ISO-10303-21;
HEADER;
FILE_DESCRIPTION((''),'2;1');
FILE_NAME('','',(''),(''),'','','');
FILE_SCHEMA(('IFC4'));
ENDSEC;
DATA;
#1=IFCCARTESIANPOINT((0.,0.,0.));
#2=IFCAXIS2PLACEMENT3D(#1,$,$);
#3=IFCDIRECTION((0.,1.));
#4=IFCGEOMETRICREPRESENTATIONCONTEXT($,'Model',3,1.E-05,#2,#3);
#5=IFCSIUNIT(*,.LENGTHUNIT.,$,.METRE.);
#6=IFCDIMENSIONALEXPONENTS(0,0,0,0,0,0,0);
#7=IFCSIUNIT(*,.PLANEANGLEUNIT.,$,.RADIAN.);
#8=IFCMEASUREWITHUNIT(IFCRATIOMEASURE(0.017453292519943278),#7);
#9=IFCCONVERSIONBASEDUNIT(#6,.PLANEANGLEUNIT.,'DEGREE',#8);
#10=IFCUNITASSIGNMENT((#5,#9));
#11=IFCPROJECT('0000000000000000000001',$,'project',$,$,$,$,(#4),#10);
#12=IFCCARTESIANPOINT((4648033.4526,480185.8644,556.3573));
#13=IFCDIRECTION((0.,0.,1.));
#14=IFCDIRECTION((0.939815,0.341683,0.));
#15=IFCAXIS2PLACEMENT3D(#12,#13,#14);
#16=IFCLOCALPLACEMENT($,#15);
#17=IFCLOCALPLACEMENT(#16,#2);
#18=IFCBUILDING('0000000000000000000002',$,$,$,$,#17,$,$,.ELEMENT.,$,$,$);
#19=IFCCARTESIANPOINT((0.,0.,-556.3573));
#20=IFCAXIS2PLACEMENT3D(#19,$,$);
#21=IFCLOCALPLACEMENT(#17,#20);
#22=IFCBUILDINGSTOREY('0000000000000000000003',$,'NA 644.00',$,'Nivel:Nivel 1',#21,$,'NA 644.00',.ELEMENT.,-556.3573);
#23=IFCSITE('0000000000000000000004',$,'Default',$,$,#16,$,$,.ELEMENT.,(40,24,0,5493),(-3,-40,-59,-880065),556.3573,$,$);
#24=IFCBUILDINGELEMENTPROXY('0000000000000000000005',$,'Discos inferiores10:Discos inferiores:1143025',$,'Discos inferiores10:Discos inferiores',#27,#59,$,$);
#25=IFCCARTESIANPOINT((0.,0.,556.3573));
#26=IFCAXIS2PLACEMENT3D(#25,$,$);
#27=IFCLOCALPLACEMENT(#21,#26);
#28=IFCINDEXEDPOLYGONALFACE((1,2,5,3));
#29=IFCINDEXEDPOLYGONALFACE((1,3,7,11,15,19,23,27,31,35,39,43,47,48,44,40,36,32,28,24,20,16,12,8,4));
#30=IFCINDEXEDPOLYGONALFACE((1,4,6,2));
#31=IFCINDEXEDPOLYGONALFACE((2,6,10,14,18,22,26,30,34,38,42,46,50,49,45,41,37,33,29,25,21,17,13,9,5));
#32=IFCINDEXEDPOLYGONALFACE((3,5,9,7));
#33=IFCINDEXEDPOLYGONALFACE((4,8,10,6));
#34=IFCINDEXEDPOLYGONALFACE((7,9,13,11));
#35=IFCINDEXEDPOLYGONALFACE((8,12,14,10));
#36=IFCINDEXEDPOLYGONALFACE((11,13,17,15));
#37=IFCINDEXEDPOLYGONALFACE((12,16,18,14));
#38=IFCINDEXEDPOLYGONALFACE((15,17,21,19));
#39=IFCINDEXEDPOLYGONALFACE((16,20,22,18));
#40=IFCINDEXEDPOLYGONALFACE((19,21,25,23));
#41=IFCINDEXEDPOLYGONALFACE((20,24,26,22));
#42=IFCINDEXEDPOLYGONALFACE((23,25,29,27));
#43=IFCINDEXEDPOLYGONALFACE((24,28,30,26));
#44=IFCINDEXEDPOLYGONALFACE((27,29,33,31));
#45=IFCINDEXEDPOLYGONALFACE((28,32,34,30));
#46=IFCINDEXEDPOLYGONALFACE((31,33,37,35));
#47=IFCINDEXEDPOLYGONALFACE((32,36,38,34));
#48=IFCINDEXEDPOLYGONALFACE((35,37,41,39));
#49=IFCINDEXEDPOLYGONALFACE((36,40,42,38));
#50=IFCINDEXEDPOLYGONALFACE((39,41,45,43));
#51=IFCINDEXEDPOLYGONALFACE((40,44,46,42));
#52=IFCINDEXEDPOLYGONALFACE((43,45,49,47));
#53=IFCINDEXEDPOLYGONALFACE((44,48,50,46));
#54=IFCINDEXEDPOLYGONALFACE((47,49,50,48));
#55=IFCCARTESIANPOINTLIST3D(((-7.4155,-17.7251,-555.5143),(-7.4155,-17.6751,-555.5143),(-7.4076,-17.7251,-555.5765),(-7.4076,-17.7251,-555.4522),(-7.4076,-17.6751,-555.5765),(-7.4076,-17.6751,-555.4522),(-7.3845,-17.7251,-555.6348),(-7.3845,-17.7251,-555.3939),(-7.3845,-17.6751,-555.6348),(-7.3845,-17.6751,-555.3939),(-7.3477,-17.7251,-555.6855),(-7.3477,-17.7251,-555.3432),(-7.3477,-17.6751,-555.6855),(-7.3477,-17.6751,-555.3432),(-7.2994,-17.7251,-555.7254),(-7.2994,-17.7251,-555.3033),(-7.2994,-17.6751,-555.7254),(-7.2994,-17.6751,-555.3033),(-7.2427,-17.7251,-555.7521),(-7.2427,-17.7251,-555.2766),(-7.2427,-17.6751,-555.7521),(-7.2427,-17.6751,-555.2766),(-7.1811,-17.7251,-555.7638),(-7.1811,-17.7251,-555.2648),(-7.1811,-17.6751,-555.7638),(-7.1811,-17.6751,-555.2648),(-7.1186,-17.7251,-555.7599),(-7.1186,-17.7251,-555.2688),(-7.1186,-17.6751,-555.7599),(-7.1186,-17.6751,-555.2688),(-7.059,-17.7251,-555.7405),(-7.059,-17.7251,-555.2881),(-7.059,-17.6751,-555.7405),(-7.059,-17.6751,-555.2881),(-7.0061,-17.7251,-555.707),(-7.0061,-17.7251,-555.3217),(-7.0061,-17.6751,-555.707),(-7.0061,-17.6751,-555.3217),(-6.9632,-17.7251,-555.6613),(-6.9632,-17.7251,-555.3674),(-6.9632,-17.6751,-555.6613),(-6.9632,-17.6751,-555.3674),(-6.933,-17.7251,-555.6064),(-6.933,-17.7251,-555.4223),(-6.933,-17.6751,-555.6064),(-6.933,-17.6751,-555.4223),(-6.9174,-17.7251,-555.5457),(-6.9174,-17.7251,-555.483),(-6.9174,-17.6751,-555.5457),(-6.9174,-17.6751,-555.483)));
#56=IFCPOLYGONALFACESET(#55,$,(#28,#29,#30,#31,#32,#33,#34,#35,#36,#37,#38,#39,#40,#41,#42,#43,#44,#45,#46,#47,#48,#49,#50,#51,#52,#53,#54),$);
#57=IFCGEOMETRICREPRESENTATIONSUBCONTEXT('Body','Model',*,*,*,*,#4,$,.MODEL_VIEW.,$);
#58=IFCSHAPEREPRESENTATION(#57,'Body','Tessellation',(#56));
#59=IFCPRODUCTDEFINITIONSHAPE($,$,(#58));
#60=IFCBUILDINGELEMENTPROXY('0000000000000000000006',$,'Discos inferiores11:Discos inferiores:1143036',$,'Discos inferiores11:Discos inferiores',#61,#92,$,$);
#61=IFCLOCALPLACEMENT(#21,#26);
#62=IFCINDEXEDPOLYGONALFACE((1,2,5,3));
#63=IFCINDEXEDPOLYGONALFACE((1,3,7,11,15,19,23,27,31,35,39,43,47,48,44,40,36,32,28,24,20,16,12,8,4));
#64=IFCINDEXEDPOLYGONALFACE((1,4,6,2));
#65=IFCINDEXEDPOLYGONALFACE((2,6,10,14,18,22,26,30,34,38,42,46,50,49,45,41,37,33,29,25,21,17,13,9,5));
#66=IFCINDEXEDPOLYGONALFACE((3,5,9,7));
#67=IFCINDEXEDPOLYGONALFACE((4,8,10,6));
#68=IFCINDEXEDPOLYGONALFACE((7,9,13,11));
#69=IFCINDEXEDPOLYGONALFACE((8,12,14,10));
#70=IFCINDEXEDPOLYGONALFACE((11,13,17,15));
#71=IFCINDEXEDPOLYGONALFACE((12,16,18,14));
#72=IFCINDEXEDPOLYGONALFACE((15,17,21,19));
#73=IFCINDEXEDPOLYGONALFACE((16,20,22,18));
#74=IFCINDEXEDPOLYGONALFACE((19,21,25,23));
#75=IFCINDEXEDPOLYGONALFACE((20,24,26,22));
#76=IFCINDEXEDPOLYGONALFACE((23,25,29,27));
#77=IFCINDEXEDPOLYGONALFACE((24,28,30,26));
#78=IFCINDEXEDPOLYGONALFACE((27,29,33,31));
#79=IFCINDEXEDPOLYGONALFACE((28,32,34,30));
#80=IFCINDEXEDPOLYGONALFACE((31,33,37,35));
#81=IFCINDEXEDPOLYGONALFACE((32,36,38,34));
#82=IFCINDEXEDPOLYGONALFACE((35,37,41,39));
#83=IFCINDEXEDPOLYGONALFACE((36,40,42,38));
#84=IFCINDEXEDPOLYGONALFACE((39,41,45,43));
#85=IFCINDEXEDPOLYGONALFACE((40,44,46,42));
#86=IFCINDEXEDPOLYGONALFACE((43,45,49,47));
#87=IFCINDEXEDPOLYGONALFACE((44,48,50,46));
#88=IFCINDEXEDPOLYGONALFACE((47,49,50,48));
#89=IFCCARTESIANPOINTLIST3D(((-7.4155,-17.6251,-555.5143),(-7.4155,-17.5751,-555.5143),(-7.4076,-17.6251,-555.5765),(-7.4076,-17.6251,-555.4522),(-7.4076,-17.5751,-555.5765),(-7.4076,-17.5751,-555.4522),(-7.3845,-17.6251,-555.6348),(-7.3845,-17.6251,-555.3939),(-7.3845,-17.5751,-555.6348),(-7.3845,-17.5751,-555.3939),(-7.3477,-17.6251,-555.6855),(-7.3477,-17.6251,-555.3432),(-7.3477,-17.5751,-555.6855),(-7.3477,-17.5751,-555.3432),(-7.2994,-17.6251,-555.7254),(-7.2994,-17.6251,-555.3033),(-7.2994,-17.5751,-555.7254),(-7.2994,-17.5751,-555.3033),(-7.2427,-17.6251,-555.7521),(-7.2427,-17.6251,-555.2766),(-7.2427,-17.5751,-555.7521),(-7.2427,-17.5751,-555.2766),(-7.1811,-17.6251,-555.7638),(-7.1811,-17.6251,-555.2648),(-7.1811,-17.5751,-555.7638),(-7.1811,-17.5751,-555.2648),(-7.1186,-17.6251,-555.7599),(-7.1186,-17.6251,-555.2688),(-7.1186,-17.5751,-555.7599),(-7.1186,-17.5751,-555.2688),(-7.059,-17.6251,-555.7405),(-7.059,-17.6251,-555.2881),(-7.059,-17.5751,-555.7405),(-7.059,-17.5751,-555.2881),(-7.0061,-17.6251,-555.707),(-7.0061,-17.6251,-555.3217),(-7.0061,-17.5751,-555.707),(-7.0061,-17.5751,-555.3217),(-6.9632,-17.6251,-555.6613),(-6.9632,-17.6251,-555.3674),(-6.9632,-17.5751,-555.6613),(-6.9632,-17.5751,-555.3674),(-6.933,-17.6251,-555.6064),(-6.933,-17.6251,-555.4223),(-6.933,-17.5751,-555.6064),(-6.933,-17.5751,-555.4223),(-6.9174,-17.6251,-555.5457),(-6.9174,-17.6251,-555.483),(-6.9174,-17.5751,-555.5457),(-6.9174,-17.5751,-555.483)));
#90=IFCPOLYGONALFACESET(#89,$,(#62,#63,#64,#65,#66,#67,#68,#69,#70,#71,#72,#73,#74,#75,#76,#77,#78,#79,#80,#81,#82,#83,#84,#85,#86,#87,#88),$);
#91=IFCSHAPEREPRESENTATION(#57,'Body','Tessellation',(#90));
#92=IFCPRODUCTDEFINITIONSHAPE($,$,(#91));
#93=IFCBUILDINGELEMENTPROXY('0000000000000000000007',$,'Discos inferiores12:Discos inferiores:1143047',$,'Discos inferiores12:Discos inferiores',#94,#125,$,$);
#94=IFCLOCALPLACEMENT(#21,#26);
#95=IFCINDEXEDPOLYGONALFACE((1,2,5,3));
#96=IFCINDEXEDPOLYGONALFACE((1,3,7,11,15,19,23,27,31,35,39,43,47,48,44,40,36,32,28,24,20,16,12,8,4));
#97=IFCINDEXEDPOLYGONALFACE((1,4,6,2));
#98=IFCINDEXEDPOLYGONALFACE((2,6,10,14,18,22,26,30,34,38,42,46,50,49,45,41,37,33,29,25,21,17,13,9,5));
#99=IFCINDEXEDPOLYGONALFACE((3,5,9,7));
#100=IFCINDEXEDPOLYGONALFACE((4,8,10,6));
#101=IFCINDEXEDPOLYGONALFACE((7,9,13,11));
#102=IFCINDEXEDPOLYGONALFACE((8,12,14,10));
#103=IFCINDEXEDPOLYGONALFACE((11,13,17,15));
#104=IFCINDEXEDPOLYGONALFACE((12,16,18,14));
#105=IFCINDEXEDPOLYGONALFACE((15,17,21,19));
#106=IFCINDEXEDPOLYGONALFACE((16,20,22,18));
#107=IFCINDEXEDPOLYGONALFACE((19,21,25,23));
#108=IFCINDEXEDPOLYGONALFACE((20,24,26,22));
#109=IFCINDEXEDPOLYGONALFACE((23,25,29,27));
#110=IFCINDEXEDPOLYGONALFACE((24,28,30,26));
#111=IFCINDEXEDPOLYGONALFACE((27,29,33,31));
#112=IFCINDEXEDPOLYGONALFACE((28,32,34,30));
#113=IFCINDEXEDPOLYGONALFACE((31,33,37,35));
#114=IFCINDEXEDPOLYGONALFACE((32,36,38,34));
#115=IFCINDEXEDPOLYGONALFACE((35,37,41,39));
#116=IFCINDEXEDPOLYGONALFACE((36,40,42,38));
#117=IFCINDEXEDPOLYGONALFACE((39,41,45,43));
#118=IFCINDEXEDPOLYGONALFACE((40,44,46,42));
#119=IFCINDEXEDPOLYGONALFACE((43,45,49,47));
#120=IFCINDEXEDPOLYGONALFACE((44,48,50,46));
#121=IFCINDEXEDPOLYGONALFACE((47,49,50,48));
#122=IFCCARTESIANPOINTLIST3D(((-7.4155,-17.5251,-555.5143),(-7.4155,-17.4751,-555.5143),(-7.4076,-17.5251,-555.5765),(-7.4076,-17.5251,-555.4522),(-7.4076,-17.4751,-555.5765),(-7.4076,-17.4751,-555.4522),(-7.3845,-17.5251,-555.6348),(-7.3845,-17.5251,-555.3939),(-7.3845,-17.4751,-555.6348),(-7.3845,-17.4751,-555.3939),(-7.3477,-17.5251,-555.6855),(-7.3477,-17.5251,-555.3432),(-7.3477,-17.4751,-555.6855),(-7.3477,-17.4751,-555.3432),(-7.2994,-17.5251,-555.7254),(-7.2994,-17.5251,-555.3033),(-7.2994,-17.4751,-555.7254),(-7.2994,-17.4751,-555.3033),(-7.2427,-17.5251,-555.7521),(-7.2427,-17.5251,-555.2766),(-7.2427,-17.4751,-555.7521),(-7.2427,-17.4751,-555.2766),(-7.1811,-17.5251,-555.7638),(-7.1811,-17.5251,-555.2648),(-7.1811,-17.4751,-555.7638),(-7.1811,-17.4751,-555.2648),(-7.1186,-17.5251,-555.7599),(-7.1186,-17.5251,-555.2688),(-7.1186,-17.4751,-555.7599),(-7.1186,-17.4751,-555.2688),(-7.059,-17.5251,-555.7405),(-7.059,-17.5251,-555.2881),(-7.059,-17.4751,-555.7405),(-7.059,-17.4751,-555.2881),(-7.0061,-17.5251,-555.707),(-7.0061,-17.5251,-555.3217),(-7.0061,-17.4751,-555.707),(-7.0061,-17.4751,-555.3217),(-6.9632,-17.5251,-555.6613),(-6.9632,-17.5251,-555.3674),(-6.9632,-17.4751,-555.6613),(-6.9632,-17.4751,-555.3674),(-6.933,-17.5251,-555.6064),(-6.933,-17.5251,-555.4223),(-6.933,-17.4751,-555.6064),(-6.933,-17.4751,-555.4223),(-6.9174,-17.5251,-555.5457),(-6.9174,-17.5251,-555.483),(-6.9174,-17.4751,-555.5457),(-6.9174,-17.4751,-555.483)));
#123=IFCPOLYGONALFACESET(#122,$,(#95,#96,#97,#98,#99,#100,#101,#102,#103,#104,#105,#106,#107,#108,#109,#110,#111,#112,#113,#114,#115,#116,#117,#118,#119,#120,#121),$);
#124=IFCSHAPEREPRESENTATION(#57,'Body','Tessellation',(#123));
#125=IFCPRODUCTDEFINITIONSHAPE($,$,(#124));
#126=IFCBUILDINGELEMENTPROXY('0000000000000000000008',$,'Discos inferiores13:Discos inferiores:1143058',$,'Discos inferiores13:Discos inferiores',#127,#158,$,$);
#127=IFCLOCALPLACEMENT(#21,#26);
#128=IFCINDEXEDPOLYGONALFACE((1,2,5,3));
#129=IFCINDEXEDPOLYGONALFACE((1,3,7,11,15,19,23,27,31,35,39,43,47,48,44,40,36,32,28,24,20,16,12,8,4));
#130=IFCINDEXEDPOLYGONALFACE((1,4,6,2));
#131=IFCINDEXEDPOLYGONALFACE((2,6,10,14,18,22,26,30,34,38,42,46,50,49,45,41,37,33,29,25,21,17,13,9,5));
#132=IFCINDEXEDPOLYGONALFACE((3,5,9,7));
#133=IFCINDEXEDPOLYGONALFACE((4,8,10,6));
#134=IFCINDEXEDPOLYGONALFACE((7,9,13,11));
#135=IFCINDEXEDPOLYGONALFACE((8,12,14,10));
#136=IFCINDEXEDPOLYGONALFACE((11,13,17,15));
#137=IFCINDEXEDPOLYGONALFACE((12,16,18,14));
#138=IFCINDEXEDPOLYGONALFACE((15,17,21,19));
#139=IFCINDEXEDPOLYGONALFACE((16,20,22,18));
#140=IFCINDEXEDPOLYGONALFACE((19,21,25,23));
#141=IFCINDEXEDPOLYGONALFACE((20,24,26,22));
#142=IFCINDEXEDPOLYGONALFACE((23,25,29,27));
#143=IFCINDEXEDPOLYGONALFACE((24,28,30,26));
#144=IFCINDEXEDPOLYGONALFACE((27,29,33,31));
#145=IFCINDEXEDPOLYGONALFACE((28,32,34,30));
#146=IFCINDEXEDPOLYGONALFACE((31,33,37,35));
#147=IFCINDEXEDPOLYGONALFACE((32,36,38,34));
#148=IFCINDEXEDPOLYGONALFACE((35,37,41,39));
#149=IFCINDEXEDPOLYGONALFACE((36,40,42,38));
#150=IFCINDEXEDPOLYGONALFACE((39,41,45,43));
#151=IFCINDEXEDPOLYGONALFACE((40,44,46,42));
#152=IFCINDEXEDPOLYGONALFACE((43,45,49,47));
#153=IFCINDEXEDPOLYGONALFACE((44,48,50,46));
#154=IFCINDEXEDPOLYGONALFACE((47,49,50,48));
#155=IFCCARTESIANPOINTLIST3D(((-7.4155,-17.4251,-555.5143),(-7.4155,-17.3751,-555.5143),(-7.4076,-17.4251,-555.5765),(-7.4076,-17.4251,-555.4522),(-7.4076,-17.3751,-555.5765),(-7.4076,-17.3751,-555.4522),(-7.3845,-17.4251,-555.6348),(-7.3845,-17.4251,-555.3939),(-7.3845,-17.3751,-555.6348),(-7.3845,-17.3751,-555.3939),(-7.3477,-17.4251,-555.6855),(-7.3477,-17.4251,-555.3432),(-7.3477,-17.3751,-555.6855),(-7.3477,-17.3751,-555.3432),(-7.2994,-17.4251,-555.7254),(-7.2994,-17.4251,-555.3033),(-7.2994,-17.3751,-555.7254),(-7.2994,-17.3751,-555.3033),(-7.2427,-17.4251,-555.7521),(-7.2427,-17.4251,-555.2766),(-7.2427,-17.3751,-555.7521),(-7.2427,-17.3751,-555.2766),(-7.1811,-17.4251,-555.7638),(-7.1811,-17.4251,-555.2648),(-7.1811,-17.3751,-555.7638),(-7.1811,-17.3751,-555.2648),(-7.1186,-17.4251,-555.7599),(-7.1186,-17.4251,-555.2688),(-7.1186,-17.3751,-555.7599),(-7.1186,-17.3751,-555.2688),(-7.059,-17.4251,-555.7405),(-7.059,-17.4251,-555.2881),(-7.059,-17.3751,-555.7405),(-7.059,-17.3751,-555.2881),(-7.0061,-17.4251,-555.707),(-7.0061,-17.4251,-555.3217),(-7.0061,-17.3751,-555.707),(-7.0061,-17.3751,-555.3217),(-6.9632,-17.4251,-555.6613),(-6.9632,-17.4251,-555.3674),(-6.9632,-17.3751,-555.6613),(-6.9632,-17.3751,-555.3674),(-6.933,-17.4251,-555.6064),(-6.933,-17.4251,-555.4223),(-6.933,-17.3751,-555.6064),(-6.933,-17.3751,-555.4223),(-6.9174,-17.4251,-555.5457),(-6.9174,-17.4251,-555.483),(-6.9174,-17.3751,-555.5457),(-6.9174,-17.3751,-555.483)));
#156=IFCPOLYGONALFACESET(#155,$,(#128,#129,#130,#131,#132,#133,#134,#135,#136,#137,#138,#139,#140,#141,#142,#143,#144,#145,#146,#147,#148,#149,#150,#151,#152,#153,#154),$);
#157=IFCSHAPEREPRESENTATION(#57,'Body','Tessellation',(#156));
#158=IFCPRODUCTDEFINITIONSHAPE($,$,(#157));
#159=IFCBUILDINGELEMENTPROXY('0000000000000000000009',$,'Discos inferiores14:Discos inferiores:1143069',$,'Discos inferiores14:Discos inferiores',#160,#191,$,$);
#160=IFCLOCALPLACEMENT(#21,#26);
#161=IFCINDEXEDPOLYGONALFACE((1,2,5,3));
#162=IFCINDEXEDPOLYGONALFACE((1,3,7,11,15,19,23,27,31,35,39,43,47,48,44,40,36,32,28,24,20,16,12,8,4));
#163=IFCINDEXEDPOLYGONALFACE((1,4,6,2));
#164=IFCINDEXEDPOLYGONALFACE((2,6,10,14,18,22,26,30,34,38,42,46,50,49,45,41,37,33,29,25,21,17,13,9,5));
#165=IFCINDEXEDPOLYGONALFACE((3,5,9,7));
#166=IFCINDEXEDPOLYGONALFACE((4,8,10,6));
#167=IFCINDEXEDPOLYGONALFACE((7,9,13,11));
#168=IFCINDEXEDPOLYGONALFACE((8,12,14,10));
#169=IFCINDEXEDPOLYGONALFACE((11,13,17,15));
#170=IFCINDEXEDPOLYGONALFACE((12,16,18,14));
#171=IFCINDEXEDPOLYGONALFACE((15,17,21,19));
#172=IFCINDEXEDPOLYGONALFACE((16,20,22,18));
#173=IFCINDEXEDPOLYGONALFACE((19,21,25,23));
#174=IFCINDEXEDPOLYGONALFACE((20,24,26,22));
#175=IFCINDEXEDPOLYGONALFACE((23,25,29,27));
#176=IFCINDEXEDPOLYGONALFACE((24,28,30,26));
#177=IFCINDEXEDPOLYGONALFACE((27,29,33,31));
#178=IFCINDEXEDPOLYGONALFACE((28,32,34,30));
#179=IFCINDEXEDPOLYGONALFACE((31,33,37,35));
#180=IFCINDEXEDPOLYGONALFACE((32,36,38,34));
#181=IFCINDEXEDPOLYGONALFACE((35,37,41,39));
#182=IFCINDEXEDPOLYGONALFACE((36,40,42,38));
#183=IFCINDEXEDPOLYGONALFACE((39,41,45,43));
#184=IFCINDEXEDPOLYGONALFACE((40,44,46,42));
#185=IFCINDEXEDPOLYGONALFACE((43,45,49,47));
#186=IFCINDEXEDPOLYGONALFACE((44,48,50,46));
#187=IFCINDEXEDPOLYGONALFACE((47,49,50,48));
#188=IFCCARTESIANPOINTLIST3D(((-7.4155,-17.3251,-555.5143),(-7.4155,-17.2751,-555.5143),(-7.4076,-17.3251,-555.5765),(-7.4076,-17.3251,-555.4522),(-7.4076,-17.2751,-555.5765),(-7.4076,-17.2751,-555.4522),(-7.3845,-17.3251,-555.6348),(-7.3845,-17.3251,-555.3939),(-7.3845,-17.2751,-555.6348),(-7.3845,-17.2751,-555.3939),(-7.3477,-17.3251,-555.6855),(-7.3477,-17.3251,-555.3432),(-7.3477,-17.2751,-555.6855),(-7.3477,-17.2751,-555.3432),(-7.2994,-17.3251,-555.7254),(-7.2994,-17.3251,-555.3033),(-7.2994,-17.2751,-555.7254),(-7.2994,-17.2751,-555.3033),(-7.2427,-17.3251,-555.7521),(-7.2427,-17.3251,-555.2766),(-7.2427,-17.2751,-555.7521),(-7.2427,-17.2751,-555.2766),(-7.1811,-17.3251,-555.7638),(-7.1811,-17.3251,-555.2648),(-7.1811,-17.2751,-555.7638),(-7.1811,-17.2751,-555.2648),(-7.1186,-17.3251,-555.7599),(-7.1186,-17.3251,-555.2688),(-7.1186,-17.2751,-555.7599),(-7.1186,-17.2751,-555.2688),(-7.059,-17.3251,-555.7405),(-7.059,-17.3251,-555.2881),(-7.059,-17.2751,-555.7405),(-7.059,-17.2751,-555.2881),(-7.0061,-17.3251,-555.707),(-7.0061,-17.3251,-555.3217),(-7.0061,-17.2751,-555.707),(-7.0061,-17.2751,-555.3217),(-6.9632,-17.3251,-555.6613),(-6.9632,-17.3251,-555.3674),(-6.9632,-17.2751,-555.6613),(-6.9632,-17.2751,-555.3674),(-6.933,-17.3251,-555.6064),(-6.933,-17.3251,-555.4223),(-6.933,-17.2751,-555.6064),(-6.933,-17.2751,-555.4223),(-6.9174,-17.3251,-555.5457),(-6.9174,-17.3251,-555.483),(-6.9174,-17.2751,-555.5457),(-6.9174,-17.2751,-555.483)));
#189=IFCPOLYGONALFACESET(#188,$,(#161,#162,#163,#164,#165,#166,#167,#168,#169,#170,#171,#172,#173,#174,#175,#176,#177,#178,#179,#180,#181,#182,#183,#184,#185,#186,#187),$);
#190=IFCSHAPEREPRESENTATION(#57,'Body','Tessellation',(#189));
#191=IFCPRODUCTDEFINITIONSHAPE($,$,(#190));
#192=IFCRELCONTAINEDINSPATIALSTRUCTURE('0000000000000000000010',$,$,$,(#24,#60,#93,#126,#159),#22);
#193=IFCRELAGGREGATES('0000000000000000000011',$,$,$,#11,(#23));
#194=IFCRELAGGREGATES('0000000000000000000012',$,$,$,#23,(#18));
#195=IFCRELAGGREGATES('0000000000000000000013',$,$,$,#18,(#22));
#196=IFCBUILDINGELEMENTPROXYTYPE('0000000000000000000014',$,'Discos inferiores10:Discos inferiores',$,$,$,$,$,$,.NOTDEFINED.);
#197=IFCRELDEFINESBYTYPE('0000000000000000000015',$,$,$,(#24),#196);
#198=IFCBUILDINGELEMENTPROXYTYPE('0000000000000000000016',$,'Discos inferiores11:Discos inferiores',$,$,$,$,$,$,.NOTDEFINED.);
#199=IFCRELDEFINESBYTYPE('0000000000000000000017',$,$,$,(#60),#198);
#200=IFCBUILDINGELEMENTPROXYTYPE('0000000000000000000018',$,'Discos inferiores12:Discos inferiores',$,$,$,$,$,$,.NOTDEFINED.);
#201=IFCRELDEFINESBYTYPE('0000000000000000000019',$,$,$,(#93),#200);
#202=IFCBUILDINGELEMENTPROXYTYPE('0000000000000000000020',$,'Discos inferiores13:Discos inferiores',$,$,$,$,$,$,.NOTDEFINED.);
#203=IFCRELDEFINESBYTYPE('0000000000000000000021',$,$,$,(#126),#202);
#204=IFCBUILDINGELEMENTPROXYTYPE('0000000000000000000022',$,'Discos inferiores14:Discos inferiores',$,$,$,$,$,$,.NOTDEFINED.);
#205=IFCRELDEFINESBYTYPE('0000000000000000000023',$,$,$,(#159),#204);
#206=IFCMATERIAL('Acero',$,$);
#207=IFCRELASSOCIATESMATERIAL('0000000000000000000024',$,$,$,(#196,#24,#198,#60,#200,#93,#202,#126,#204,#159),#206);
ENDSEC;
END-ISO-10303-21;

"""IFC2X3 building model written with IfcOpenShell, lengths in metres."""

from ifc_helpers import new_model, entity, si_unit, converted_unit, direction, frame, origin, origin_2d_with_axis, place, context, subcontext, project, spatial, circle, extrude, source, transform, mapped, material, type_object, type_shapes, element, save


model = new_model("IFC2X3")

# Units and contexts
model_context = context("Model", 3, precision=1e-05, world=origin(), true_north=direction((0.0, 1.0)))
body_context = subcontext(model_context, "Body", "Model", "MODEL_VIEW")
ifc_project = project(units=[si_unit("LENGTHUNIT", "METRE"), converted_unit("PLANEANGLEUNIT", "DEGREE", entity("IfcRatioMeasure", 0.017453292519943278), si_unit("PLANEANGLEUNIT", "RADIAN"), dimensions=[0, 0, 0, 0, 0, 0, 0])], contexts=[model_context])

# Site, building, storey
site_placement = place(None, frame((4648033.4526, 480185.8644, 556.3573), z_axis=(0.0, 0.0, 1.0), x_axis=(0.939815, 0.341683, 0.0)))
site = spatial("IfcSite", under=ifc_project, at=site_placement, Name="Default", CompositionType="ELEMENT", RefLatitude=(40, 24, 0, 5493), RefLongitude=(-3, -40, -59, -880065), RefElevation=556.3573)
building_placement = place(site_placement, origin())
building = spatial("IfcBuilding", under=site, at=building_placement, CompositionType="ELEMENT")
storey_placement = place(building_placement, frame((0.0, 0.0, -556.3573)))
storey = spatial("IfcBuildingStorey", under=building, at=storey_placement, Name="NA 644.00", ObjectType="Nivel:Nivel 1", LongName="NA 644.00", CompositionType="ELEMENT", Elevation=-556.3573)

# Building element proxies
ifc_material_1 = material(Name="Acero")
building_element_proxy_type_1 = type_object("IfcBuildingElementProxyType", Name="Discos inferiores10:Discos inferiores", PredefinedType="NOTDEFINED", material=ifc_material_1)
shared_shape_1 = source(origin(), body_context, "Body", "SweptSolid", [
    extrude(circle(Radius=0.25, at=origin_2d_with_axis()), frame((-7.1655, -17.7251, -555.5143), z_axis=(0.0, 1.0, 0.0), x_axis=(-1.0, 0.0, 0.0)), (0.0, 0.0, 1.0), 0.05),
])
type_shapes(building_element_proxy_type_1, [shared_shape_1])
proxy_1_placement = place(storey_placement, frame((0.0, 0.0, 556.3573)))
element("IfcBuildingElementProxy", 1, at=proxy_1_placement, inside=storey, type_object=building_element_proxy_type_1, material=ifc_material_1, Name="Discos inferiores10:Discos inferiores:1143025", ObjectType="Discos inferiores10:Discos inferiores", context=body_context, shape_type="MappedRepresentation", body=[
    mapped(shared_shape_1, transform((0.0, 0.0, 0.0), scale=1.0)),
])
building_element_proxy_type_2 = type_object("IfcBuildingElementProxyType", Name="Discos inferiores11:Discos inferiores", PredefinedType="NOTDEFINED", material=ifc_material_1)
shared_shape_2 = source(origin(), body_context, "Body", "SweptSolid", [
    extrude(circle(Radius=0.25, at=origin_2d_with_axis()), frame((-7.1655, -17.6251, -555.5143), z_axis=(0.0, 1.0, 0.0), x_axis=(-1.0, 0.0, 0.0)), (0.0, 0.0, 1.0), 0.05),
])
type_shapes(building_element_proxy_type_2, [shared_shape_2])
proxy_2_placement = place(storey_placement, frame((0.0, 0.0, 556.3573)))
element("IfcBuildingElementProxy", 2, at=proxy_2_placement, inside=storey, type_object=building_element_proxy_type_2, material=ifc_material_1, Name="Discos inferiores11:Discos inferiores:1143036", ObjectType="Discos inferiores11:Discos inferiores", context=body_context, shape_type="MappedRepresentation", body=[
    mapped(shared_shape_2, transform((0.0, 0.0, 0.0), scale=1.0)),
])
building_element_proxy_type_3 = type_object("IfcBuildingElementProxyType", Name="Discos inferiores12:Discos inferiores", PredefinedType="NOTDEFINED", material=ifc_material_1)
shared_shape_3 = source(origin(), body_context, "Body", "SweptSolid", [
    extrude(circle(Radius=0.25, at=origin_2d_with_axis()), frame((-7.1655, -17.5251, -555.5143), z_axis=(0.0, 1.0, 0.0), x_axis=(-1.0, 0.0, 0.0)), (0.0, 0.0, 1.0), 0.05),
])
type_shapes(building_element_proxy_type_3, [shared_shape_3])
proxy_3_placement = place(storey_placement, frame((0.0, 0.0, 556.3573)))
element("IfcBuildingElementProxy", 3, at=proxy_3_placement, inside=storey, type_object=building_element_proxy_type_3, material=ifc_material_1, Name="Discos inferiores12:Discos inferiores:1143047", ObjectType="Discos inferiores12:Discos inferiores", context=body_context, shape_type="MappedRepresentation", body=[
    mapped(shared_shape_3, transform((0.0, 0.0, 0.0), scale=1.0)),
])
building_element_proxy_type_4 = type_object("IfcBuildingElementProxyType", Name="Discos inferiores13:Discos inferiores", PredefinedType="NOTDEFINED", material=ifc_material_1)
shared_shape_4 = source(origin(), body_context, "Body", "SweptSolid", [
    extrude(circle(Radius=0.25, at=origin_2d_with_axis()), frame((-7.1655, -17.4251, -555.5143), z_axis=(0.0, 1.0, 0.0), x_axis=(-1.0, 0.0, 0.0)), (0.0, 0.0, 1.0), 0.05),
])
type_shapes(building_element_proxy_type_4, [shared_shape_4])
proxy_4_placement = place(storey_placement, frame((0.0, 0.0, 556.3573)))
element("IfcBuildingElementProxy", 4, at=proxy_4_placement, inside=storey, type_object=building_element_proxy_type_4, material=ifc_material_1, Name="Discos inferiores13:Discos inferiores:1143058", ObjectType="Discos inferiores13:Discos inferiores", context=body_context, shape_type="MappedRepresentation", body=[
    mapped(shared_shape_4, transform((0.0, 0.0, 0.0), scale=1.0)),
])
building_element_proxy_type_5 = type_object("IfcBuildingElementProxyType", Name="Discos inferiores14:Discos inferiores", PredefinedType="NOTDEFINED", material=ifc_material_1)
shared_shape_5 = source(origin(), body_context, "Body", "SweptSolid", [
    extrude(circle(Radius=0.25, at=origin_2d_with_axis()), frame((-7.1655, -17.3251, -555.5143), z_axis=(0.0, 1.0, 0.0), x_axis=(-1.0, 0.0, 0.0)), (0.0, 0.0, 1.0), 0.05),
])
type_shapes(building_element_proxy_type_5, [shared_shape_5])
proxy_5_placement = place(storey_placement, frame((0.0, 0.0, 556.3573)))
element("IfcBuildingElementProxy", 5, at=proxy_5_placement, inside=storey, type_object=building_element_proxy_type_5, material=ifc_material_1, Name="Discos inferiores14:Discos inferiores:1143069", ObjectType="Discos inferiores14:Discos inferiores", context=body_context, shape_type="MappedRepresentation", body=[
    mapped(shared_shape_5, transform((0.0, 0.0, 0.0), scale=1.0)),
])

save(model, "model.ifc")
